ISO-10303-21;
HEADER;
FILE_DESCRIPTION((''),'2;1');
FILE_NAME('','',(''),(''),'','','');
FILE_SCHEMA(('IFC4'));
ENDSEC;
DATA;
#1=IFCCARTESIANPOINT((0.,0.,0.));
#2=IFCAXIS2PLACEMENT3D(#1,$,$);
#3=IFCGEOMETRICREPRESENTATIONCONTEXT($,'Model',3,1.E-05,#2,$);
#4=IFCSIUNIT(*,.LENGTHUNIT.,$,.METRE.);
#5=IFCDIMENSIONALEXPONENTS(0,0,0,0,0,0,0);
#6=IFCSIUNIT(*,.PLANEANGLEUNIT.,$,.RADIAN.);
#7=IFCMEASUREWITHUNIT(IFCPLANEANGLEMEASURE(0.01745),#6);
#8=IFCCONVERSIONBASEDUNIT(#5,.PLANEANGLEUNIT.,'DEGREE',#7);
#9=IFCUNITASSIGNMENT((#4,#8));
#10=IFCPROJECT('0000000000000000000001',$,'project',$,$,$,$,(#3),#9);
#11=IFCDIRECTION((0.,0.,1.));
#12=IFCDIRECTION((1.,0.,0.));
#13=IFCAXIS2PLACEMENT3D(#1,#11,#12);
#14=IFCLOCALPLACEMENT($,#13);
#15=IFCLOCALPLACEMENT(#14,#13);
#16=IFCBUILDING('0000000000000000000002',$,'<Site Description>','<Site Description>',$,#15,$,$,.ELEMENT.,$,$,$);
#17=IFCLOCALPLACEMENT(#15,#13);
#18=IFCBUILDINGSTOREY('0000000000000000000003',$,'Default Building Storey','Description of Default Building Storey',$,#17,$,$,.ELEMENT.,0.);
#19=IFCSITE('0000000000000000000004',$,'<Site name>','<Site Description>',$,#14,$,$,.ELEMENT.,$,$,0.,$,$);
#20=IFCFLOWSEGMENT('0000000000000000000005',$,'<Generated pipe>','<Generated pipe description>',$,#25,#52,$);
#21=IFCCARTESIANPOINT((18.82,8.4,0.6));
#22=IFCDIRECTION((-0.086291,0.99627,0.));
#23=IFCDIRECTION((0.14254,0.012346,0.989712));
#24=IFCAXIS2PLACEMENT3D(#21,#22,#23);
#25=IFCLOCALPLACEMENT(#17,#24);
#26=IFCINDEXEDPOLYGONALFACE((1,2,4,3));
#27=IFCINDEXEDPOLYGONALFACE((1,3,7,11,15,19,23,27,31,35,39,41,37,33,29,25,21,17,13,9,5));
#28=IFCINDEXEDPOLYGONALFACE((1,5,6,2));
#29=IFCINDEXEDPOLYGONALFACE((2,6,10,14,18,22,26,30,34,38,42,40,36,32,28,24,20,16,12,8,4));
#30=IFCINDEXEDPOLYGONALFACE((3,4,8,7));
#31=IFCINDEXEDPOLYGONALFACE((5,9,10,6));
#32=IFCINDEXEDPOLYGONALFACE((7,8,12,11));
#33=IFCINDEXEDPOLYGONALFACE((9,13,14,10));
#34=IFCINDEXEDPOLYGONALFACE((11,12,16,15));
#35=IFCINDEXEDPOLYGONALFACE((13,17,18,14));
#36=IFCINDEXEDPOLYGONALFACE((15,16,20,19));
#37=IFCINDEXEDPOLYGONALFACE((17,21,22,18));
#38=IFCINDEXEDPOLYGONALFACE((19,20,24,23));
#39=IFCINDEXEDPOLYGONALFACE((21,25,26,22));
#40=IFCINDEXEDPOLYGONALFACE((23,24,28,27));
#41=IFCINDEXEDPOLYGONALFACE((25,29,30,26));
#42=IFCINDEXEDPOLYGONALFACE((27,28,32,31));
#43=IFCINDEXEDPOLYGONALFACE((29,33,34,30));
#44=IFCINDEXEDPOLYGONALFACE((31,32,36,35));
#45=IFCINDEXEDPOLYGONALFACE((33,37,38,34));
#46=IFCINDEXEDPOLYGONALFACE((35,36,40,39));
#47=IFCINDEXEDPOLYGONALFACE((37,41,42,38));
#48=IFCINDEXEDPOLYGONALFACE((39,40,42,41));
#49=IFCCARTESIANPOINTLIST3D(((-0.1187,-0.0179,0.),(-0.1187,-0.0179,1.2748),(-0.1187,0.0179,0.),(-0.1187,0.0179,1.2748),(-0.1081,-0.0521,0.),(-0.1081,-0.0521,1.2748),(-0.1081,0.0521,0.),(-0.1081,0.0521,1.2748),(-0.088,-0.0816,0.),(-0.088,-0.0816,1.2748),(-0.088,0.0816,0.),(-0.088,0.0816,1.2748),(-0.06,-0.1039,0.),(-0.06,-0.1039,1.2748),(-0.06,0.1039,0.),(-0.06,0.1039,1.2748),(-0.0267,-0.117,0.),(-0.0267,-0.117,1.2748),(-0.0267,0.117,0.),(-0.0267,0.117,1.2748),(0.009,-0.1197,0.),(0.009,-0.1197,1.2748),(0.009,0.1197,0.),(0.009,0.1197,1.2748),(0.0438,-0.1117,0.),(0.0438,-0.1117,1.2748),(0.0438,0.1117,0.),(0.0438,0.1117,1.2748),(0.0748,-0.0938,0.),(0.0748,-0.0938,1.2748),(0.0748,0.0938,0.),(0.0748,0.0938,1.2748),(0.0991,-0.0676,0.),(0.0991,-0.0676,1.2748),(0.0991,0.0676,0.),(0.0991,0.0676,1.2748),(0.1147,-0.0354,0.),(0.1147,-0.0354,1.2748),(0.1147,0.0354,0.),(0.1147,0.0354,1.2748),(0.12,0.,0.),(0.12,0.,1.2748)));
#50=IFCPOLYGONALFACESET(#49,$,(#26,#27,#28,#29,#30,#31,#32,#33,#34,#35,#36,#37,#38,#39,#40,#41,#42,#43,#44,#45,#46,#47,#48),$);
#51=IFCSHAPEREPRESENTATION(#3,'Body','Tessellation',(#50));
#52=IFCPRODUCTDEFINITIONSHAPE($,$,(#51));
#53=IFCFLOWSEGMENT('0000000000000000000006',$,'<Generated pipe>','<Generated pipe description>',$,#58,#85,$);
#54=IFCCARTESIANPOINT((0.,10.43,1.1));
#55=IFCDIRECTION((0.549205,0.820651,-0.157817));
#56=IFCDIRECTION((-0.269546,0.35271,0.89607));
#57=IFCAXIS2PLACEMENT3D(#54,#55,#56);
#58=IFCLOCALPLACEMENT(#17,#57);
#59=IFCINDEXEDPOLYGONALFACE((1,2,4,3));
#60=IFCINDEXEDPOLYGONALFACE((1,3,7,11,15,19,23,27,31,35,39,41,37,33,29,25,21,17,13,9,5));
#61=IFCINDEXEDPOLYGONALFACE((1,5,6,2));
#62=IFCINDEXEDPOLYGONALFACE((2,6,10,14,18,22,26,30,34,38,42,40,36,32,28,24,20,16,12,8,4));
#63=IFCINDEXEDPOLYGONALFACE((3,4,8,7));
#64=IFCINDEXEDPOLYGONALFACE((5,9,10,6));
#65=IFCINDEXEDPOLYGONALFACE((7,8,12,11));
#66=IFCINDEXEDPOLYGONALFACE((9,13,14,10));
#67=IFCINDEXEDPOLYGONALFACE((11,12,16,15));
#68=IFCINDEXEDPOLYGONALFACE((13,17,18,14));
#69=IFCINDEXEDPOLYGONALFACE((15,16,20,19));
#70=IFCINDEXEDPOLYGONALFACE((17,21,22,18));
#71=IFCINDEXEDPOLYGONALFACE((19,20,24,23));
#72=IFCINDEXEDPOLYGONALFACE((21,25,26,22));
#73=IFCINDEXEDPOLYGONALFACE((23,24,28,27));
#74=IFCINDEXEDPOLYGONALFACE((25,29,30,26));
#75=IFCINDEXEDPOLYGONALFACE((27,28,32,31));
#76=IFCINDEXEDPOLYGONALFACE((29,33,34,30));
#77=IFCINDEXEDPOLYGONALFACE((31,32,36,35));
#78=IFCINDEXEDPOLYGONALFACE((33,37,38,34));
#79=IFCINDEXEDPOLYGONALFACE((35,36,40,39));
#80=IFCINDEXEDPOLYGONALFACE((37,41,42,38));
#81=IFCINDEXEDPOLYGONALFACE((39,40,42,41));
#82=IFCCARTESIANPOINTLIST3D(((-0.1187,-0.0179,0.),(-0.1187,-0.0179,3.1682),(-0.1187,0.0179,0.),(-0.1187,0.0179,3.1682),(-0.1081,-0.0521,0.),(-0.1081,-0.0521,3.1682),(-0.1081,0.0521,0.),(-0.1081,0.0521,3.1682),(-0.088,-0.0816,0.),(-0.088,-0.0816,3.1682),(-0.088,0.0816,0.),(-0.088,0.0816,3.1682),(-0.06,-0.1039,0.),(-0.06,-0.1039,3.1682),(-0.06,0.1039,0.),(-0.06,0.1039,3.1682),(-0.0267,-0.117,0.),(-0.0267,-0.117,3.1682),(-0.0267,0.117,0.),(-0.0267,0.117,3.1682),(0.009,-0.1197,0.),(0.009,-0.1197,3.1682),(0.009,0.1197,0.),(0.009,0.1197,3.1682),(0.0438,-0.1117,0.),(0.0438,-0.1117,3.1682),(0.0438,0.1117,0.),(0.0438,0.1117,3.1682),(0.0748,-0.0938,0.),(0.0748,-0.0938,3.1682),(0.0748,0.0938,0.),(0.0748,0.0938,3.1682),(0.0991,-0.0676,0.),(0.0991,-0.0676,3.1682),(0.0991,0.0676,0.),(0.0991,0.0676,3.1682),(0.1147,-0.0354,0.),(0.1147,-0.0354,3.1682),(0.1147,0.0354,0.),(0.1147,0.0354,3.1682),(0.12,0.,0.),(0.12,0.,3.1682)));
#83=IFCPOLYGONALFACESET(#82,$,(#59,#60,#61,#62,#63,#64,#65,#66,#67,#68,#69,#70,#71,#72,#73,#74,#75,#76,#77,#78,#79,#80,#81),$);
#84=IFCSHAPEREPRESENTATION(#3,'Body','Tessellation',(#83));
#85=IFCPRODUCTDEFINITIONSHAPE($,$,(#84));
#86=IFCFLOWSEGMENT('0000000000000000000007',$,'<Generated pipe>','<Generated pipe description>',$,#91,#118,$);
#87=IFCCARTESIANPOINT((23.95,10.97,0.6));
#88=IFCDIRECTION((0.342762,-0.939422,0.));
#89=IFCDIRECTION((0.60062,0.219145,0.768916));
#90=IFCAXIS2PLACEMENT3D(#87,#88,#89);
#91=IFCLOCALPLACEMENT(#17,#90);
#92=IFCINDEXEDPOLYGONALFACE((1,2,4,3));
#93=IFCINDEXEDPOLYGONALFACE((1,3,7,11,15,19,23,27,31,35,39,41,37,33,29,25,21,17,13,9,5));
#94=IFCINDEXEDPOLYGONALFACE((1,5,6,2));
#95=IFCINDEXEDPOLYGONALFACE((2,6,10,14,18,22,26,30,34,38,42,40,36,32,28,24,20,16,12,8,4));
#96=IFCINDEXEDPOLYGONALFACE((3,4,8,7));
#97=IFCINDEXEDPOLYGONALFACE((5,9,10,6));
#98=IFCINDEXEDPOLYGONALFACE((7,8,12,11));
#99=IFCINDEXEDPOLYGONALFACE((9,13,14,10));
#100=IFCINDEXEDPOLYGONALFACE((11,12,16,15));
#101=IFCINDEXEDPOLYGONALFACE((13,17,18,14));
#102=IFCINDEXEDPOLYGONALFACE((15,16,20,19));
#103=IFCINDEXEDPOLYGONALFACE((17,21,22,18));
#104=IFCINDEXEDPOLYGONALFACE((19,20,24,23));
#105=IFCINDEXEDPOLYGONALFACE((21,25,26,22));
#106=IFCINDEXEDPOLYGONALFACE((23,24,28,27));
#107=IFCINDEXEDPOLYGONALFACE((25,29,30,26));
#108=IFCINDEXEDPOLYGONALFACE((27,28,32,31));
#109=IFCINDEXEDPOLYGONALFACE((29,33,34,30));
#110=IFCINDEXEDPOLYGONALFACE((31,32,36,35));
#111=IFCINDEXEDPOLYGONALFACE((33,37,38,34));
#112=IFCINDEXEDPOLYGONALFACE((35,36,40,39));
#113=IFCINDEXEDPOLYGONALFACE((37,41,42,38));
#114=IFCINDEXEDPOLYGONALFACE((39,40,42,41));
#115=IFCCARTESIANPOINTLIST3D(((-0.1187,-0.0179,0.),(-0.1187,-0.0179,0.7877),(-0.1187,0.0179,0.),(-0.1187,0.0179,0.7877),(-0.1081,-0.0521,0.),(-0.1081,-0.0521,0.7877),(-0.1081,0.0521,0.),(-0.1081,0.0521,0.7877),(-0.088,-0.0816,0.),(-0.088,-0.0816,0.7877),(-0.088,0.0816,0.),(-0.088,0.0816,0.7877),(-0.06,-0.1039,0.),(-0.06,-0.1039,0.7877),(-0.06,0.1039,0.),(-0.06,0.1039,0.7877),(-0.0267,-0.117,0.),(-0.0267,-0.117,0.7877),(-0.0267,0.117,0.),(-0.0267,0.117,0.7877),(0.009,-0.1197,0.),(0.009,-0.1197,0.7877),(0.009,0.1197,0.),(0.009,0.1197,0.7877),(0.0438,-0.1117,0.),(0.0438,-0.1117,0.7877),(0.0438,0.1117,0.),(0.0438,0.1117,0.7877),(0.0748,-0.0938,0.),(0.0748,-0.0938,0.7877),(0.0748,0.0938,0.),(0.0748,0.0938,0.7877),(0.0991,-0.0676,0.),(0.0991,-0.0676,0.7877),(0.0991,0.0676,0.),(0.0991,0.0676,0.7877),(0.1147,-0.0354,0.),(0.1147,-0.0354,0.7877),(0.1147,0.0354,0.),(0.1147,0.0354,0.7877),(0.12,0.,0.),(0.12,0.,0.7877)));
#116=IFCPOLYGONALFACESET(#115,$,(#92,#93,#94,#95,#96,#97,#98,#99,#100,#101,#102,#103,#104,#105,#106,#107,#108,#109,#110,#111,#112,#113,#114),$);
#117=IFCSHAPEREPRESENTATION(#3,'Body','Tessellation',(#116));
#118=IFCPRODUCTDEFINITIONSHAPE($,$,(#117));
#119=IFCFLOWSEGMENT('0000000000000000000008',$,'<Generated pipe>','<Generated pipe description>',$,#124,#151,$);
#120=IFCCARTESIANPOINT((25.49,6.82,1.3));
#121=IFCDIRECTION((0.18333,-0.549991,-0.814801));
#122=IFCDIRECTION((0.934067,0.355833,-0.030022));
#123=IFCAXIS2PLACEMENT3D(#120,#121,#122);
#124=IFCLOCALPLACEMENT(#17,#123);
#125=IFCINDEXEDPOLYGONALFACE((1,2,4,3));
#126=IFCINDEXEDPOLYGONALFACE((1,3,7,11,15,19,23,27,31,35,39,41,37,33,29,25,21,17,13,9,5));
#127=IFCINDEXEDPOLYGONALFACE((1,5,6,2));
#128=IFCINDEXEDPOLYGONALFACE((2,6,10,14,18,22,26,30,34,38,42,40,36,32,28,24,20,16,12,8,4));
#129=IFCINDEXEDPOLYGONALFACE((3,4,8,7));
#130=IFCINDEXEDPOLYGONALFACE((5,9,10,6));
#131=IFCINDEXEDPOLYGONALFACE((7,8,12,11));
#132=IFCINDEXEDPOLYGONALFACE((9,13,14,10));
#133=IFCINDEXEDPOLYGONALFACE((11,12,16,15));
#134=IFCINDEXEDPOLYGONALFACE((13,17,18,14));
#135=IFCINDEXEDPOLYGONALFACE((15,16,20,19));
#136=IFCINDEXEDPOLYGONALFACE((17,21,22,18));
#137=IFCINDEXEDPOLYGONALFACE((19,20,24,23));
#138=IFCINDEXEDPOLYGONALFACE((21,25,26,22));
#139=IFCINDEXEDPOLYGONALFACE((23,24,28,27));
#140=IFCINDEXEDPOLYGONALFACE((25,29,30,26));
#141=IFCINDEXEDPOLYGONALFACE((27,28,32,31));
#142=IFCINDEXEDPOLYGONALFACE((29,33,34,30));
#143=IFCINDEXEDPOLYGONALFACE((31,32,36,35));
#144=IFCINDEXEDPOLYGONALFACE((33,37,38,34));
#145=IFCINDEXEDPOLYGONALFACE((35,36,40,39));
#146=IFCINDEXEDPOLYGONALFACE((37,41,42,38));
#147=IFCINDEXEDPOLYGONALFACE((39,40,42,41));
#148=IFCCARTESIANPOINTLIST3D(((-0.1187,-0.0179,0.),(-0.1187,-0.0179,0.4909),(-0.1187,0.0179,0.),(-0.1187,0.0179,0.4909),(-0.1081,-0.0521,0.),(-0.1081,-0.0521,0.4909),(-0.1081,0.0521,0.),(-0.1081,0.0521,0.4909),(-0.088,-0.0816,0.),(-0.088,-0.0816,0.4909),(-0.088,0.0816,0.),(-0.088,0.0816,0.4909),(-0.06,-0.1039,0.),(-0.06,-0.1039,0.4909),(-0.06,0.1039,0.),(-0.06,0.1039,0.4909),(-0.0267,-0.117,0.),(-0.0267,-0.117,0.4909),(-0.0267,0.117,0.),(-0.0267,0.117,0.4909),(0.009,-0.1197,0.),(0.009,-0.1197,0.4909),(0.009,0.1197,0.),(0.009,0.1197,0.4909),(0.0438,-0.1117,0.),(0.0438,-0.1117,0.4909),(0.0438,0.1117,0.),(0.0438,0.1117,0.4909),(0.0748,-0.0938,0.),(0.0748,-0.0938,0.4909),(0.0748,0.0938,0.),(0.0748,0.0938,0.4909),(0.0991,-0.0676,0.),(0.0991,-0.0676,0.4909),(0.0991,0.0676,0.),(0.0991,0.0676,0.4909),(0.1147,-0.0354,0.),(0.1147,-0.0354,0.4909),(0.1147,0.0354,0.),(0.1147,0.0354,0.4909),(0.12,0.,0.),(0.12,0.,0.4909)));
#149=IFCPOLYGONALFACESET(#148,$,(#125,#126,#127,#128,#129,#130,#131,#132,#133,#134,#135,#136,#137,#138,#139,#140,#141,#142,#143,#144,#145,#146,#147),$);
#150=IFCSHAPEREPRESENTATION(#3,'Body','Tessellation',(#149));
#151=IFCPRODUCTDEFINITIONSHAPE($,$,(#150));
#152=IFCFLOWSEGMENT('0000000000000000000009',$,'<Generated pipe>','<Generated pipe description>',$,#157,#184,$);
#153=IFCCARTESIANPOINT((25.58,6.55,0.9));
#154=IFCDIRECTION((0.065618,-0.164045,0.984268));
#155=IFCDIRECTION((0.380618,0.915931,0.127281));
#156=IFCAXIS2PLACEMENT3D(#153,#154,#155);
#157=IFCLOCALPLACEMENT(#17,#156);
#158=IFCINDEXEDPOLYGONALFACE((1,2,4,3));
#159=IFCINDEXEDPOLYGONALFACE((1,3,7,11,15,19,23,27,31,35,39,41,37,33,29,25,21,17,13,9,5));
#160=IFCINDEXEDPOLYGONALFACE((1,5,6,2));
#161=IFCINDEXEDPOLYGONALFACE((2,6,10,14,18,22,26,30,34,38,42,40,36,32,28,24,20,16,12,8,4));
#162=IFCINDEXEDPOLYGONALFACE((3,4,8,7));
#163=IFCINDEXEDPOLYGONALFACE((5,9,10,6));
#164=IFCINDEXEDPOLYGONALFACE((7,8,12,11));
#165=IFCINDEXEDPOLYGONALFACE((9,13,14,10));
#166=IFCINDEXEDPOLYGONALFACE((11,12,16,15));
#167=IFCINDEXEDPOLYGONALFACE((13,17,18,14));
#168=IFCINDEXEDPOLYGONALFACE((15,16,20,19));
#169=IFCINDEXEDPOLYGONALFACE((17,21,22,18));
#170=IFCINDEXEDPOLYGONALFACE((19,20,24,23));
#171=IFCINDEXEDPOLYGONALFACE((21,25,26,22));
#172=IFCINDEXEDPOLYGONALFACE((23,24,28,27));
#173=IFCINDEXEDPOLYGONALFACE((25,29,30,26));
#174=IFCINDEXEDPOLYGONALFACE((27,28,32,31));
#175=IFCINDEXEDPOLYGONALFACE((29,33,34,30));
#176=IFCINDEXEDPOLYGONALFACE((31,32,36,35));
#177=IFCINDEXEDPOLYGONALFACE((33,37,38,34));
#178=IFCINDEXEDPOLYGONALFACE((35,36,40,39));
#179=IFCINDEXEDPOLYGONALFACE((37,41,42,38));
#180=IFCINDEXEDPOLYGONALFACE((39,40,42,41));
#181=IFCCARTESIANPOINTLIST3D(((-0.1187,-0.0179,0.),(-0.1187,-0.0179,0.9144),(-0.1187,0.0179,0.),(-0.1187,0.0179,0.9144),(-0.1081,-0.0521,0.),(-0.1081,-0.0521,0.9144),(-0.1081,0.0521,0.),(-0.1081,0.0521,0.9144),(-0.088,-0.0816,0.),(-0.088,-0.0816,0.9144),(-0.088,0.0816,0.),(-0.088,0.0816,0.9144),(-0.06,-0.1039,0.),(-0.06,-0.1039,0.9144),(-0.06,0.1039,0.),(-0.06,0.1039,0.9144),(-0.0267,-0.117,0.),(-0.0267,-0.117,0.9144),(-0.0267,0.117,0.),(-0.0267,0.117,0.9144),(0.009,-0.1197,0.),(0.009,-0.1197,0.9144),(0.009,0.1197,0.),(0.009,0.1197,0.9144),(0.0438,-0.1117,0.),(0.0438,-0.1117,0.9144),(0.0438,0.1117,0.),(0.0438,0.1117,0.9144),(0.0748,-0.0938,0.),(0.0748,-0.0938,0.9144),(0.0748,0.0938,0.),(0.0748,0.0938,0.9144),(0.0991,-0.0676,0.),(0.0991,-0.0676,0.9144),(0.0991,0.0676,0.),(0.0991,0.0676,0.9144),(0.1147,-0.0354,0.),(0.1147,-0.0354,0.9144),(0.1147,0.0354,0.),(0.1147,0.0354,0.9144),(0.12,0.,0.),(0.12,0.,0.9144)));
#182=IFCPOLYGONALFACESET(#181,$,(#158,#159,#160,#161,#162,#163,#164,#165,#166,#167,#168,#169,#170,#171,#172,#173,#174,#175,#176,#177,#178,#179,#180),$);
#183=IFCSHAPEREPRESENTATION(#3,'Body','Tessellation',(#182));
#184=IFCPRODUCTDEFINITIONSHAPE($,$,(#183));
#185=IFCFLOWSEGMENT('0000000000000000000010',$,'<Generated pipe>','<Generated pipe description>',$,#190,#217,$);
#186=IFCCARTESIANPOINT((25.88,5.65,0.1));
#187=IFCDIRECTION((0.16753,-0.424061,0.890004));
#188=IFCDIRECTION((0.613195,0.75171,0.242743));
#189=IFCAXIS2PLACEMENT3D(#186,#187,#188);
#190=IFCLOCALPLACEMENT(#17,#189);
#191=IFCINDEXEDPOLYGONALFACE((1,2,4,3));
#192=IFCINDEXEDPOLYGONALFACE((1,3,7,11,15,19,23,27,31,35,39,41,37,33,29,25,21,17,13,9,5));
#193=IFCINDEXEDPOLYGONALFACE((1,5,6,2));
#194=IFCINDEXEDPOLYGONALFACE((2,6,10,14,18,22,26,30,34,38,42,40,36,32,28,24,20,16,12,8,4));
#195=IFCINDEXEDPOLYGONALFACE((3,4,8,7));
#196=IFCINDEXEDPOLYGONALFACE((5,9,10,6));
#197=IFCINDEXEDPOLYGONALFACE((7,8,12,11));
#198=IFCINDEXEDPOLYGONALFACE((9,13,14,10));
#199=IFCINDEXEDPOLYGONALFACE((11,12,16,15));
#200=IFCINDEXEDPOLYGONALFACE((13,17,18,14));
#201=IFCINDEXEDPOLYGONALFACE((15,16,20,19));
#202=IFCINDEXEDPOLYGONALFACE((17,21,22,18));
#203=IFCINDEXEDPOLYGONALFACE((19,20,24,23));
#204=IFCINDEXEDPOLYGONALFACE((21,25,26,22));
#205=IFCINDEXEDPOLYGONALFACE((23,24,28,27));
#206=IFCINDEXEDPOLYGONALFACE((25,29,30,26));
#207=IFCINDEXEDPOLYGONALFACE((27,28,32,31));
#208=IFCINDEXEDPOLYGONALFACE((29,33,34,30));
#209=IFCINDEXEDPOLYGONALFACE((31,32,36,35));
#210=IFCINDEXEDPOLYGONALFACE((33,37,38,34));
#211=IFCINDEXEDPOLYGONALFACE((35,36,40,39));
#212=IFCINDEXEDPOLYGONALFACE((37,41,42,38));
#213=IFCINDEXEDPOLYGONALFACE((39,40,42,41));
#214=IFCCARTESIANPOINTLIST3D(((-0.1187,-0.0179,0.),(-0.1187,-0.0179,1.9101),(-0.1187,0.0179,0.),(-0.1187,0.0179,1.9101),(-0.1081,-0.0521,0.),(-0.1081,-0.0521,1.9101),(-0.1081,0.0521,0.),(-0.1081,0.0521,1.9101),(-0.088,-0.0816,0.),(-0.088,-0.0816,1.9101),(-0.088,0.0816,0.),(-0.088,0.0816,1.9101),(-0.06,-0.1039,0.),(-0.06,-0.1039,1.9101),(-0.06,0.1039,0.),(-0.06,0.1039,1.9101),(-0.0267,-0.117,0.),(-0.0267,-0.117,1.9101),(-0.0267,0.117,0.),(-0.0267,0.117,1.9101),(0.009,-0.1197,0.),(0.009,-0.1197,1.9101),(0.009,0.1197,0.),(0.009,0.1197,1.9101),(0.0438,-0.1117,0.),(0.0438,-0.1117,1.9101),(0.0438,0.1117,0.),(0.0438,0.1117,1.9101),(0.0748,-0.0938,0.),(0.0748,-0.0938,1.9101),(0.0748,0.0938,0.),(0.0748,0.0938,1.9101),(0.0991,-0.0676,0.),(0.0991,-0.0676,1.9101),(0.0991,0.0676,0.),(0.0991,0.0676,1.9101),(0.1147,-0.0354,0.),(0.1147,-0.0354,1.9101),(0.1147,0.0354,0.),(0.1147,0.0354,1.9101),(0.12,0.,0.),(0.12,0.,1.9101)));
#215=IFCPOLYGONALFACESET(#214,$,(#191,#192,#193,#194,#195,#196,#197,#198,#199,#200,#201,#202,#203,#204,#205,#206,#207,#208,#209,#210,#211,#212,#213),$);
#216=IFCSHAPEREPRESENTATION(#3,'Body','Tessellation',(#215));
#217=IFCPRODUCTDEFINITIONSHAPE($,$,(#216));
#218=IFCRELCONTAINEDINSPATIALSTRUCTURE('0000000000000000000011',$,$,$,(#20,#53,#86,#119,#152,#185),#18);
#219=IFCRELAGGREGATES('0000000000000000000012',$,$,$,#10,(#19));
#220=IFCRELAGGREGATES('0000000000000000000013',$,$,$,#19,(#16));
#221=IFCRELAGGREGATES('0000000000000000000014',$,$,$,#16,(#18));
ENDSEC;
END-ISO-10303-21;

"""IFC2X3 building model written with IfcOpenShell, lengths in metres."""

from ifc_helpers import new_model, entity, si_unit, converted_unit, frame, origin, origin_with_axes, origin_2d_with_axis, place, context, project, spatial, circle, extrude, element, save


model = new_model("IFC2X3")

# Units and contexts
model_context = context("Model", 3, precision=1e-05, world=origin())
ifc_project = project(units=[si_unit("LENGTHUNIT", "METRE"), converted_unit("PLANEANGLEUNIT", "DEGREE", entity("IfcPlaneAngleMeasure", 0.01745), si_unit("PLANEANGLEUNIT", "RADIAN"), dimensions=[0, 0, 0, 0, 0, 0, 0])], contexts=[model_context])

# Site, building, storey
site_placement = place(None, origin_with_axes())
site = spatial("IfcSite", under=ifc_project, at=site_placement, Name="<Site name>", Description="<Site Description>", CompositionType="ELEMENT", RefElevation=0.0)
building_placement = place(site_placement, origin_with_axes())
building = spatial("IfcBuilding", under=site, at=building_placement, Name="<Site Description>", Description="<Site Description>", CompositionType="ELEMENT")
storey_placement = place(building_placement, origin_with_axes())
storey = spatial("IfcBuildingStorey", under=building, at=storey_placement, Name="Default Building Storey", Description="Description of Default Building Storey", CompositionType="ELEMENT", Elevation=0.0)

# Flow segments
flow_segment_1_placement = place(storey_placement, frame((18.82, 8.4, 0.6), z_axis=(-0.086291, 0.99627, 0.0), x_axis=(0.14254, 0.012346, 0.989712)))
element("IfcFlowSegment", 1, at=flow_segment_1_placement, inside=storey, Name="<Generated pipe>", Description="<Generated pipe description>", context=model_context, shape_type="SweptSolid", body=[
    extrude(circle(Radius=0.12, at=origin_2d_with_axis()), origin_with_axes(), (0.0, 0.0, 1.0), 1.2748),
])
flow_segment_2_placement = place(storey_placement, frame((0.0, 10.43, 1.1), z_axis=(0.549205, 0.820651, -0.157817), x_axis=(-0.269546, 0.35271, 0.89607)))
element("IfcFlowSegment", 2, at=flow_segment_2_placement, inside=storey, Name="<Generated pipe>", Description="<Generated pipe description>", context=model_context, shape_type="SweptSolid", body=[
    extrude(circle(Radius=0.12, at=origin_2d_with_axis()), origin_with_axes(), (0.0, 0.0, 1.0), 3.1682),
])
flow_segment_3_placement = place(storey_placement, frame((23.95, 10.97, 0.6), z_axis=(0.342762, -0.939422, 0.0), x_axis=(0.60062, 0.219145, 0.768916)))
element("IfcFlowSegment", 3, at=flow_segment_3_placement, inside=storey, Name="<Generated pipe>", Description="<Generated pipe description>", context=model_context, shape_type="SweptSolid", body=[
    extrude(circle(Radius=0.12, at=origin_2d_with_axis()), origin_with_axes(), (0.0, 0.0, 1.0), 0.7877),
])
flow_segment_4_placement = place(storey_placement, frame((25.49, 6.82, 1.3), z_axis=(0.18333, -0.549991, -0.814801), x_axis=(0.934067, 0.355833, -0.030022)))
element("IfcFlowSegment", 4, at=flow_segment_4_placement, inside=storey, Name="<Generated pipe>", Description="<Generated pipe description>", context=model_context, shape_type="SweptSolid", body=[
    extrude(circle(Radius=0.12, at=origin_2d_with_axis()), origin_with_axes(), (0.0, 0.0, 1.0), 0.4909),
])
flow_segment_5_placement = place(storey_placement, frame((25.58, 6.55, 0.9), z_axis=(0.065618, -0.164045, 0.984268), x_axis=(0.380618, 0.915931, 0.127281)))
element("IfcFlowSegment", 5, at=flow_segment_5_placement, inside=storey, Name="<Generated pipe>", Description="<Generated pipe description>", context=model_context, shape_type="SweptSolid", body=[
    extrude(circle(Radius=0.12, at=origin_2d_with_axis()), origin_with_axes(), (0.0, 0.0, 1.0), 0.9144),
])
flow_segment_6_placement = place(storey_placement, frame((25.88, 5.65, 0.1), z_axis=(0.16753, -0.424061, 0.890004), x_axis=(0.613195, 0.75171, 0.242743)))
element("IfcFlowSegment", 6, at=flow_segment_6_placement, inside=storey, Name="<Generated pipe>", Description="<Generated pipe description>", context=model_context, shape_type="SweptSolid", body=[
    extrude(circle(Radius=0.12, at=origin_2d_with_axis()), origin_with_axes(), (0.0, 0.0, 1.0), 1.9101),
])

save(model, "model.ifc")
